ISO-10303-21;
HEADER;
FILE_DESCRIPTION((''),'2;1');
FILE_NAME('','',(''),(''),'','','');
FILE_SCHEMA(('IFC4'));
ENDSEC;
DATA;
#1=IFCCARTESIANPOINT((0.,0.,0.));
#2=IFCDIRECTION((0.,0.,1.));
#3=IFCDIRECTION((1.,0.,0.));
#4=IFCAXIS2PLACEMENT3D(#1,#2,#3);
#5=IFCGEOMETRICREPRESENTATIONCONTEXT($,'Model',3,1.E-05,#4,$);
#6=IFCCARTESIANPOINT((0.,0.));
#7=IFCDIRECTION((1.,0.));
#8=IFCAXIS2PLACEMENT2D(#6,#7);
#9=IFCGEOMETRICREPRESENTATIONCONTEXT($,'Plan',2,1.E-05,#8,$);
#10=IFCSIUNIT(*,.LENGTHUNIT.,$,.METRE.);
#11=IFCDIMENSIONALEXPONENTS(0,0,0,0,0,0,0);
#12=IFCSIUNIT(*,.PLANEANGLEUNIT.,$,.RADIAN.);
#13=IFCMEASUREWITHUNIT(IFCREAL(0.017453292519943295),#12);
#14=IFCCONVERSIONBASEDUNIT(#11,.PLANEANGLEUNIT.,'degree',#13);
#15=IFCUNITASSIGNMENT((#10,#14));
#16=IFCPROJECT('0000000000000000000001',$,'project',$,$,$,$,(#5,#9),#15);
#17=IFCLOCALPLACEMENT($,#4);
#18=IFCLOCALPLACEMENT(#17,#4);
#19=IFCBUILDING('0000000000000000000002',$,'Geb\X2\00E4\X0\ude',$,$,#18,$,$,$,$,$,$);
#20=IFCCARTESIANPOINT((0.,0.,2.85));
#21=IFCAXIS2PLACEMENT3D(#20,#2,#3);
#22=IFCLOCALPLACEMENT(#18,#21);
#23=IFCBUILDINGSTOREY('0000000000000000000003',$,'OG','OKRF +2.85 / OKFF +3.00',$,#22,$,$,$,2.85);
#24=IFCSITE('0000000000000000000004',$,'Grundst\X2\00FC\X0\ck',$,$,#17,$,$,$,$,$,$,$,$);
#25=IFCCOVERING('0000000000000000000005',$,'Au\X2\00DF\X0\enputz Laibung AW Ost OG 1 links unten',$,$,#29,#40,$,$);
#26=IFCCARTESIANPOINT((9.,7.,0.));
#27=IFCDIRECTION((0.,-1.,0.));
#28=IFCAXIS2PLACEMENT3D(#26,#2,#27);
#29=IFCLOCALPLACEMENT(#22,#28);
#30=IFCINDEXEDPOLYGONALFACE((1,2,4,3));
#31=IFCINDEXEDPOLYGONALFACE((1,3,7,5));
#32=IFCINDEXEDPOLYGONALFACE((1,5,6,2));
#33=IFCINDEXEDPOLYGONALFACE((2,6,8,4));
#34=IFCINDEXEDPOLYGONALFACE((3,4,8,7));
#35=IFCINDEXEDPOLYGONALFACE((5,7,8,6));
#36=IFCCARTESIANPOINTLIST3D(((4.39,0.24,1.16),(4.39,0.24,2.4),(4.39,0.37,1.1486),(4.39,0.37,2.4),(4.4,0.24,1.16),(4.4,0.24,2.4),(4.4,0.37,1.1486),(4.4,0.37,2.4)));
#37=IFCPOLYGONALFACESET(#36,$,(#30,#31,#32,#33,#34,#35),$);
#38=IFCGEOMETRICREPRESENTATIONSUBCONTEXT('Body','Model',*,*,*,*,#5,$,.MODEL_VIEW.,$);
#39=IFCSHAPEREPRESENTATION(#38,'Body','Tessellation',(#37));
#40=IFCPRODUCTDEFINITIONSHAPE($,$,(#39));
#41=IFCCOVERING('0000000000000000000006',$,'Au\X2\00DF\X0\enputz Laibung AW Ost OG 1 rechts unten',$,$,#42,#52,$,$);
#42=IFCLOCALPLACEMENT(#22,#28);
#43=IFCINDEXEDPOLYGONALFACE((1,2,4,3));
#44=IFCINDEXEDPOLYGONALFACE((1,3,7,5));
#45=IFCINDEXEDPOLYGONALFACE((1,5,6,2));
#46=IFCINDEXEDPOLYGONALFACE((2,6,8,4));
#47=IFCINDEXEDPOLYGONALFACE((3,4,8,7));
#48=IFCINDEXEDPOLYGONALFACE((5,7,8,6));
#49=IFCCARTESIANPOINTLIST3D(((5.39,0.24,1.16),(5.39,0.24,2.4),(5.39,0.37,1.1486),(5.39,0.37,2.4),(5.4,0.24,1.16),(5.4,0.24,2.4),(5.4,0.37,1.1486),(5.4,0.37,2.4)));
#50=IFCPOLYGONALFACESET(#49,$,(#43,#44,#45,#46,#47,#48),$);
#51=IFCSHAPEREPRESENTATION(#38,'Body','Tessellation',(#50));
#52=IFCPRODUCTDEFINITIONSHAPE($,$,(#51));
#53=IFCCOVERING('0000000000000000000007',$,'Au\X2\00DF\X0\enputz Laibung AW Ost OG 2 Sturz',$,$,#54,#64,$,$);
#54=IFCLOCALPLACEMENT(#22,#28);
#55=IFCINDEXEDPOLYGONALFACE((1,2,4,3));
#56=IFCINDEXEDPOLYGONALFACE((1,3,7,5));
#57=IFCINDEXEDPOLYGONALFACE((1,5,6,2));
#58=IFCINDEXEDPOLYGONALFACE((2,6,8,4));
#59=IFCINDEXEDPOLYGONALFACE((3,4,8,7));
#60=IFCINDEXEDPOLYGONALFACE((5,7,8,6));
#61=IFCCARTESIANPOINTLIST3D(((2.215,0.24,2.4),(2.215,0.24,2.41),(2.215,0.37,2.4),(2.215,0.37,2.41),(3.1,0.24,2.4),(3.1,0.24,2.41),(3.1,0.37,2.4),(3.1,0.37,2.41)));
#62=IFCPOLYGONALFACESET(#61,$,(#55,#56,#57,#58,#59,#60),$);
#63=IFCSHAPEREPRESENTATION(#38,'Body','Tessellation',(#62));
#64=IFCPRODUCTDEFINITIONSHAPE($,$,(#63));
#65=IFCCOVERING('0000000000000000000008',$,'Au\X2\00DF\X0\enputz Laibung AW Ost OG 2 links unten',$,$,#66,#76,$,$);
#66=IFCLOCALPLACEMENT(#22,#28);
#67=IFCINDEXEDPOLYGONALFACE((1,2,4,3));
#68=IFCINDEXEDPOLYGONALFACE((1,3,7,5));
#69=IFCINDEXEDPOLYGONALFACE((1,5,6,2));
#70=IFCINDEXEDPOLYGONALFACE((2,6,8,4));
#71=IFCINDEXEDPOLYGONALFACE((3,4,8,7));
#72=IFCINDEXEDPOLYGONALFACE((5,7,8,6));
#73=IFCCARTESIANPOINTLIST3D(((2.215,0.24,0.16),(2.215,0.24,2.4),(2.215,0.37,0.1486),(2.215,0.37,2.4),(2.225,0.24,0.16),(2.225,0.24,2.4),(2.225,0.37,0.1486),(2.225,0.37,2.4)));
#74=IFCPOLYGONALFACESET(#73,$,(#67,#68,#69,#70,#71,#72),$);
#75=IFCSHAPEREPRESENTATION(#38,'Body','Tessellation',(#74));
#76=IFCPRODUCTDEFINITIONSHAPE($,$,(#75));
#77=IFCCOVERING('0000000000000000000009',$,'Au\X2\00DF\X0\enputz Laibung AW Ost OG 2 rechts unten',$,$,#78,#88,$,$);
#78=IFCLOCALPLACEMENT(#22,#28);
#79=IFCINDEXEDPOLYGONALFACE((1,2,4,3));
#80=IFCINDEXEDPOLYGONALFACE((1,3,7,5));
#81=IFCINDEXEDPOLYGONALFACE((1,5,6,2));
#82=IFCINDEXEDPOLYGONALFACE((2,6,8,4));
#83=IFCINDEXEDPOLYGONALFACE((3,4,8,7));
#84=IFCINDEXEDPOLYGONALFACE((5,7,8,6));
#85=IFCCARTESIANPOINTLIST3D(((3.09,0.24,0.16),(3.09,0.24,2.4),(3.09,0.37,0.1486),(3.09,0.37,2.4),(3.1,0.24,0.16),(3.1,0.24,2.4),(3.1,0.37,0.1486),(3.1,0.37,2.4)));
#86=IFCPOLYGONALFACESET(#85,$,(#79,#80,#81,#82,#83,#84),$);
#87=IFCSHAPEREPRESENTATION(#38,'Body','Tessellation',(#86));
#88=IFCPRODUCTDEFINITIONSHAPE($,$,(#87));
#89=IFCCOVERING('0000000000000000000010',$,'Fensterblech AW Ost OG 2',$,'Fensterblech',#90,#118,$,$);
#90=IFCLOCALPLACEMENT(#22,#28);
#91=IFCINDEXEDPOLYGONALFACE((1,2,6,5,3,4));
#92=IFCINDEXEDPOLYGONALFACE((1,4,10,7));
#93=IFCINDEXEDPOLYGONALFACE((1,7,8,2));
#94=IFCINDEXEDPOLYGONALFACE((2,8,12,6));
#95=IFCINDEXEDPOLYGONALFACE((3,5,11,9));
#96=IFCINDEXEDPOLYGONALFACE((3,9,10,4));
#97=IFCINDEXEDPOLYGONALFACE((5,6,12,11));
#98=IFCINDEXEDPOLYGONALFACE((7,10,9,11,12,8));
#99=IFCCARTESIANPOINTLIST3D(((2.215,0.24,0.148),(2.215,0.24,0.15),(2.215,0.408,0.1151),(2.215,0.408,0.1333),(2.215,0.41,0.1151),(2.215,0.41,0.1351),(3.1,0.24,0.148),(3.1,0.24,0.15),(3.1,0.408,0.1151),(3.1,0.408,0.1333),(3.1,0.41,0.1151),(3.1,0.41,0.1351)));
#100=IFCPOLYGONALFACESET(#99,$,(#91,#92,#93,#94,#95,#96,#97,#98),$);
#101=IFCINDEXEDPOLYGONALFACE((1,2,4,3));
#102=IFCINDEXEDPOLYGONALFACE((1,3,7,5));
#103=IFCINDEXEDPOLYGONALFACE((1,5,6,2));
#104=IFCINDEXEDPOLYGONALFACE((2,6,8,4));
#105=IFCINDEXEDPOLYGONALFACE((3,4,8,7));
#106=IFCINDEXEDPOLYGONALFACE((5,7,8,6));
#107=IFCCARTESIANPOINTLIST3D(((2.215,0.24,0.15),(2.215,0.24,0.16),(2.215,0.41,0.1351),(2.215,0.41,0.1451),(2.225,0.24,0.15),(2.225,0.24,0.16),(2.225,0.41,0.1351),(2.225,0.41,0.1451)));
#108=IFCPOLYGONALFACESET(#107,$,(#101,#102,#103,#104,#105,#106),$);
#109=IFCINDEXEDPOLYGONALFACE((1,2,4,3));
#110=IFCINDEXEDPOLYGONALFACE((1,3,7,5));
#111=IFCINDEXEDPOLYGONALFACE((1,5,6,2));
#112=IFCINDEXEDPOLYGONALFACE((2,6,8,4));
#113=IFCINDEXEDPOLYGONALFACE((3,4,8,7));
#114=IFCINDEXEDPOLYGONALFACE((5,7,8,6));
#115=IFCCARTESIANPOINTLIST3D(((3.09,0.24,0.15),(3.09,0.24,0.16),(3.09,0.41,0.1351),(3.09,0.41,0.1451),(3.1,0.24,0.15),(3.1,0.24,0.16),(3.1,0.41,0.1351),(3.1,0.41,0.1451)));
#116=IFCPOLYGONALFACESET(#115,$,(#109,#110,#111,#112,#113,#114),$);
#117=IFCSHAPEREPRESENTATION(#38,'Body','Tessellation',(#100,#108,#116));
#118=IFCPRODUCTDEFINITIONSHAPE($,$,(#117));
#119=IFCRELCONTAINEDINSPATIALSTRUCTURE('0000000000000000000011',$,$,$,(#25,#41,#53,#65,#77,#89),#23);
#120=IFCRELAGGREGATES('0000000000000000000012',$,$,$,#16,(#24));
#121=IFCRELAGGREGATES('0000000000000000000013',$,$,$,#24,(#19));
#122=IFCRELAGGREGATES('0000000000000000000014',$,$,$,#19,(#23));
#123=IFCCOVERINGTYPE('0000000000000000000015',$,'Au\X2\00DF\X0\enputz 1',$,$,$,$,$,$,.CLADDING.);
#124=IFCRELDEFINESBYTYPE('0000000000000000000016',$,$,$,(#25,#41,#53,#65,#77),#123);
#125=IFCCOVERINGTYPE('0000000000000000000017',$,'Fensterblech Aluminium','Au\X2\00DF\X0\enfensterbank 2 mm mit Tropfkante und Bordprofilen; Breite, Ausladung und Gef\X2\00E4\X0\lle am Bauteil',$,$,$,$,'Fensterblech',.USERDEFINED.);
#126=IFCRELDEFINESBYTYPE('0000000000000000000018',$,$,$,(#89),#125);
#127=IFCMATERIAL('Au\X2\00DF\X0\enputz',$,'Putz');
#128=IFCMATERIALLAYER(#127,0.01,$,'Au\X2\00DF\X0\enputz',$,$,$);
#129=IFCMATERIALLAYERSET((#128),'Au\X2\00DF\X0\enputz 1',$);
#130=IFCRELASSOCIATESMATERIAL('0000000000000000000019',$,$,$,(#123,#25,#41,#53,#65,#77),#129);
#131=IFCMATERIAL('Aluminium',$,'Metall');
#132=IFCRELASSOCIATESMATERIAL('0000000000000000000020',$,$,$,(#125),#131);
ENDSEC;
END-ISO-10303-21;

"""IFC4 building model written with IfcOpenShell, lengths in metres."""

from ifc_helpers import new_model, entity, si_unit, converted_unit, frame, origin_with_axes, origin_2d_with_axis, place, context, subcontext, project, spatial, polyline, outline, extrude, material, layer, layer_set, layer_usage, type_object, element, save


model = new_model("IFC4")

# Units and contexts
model_context = context("Model", 3, precision=1e-05, world=origin_with_axes())
plan_context = context("Plan", 2, precision=1e-05, world=origin_2d_with_axis())
body_context = subcontext(model_context, "Body", "Model", "MODEL_VIEW")
ifc_project = project(units=[si_unit("LENGTHUNIT", "METRE"), converted_unit("PLANEANGLEUNIT", "degree", entity("IfcReal", 0.017453292519943295), si_unit("PLANEANGLEUNIT", "RADIAN"), dimensions=[0, 0, 0, 0, 0, 0, 0])], contexts=[model_context, plan_context])

# Site, building, storey
site_placement = place(None, origin_with_axes())
site = spatial("IfcSite", under=ifc_project, at=site_placement, Name="Grundstück")
building_placement = place(site_placement, origin_with_axes())
building = spatial("IfcBuilding", under=site, at=building_placement, Name="Gebäude")
storey_placement = place(building_placement, frame((0.0, 0.0, 2.85), z_axis=(0.0, 0.0, 1.0), x_axis=(1.0, 0.0, 0.0)))
storey = spatial("IfcBuildingStorey", under=building, at=storey_placement, Name="OG", Description="OKRF +2.85 / OKFF +3.00", Elevation=2.85)

# Coverings
ifc_material_1 = material(Name="Außenputz", Category="Putz")
ifc_layer_1 = layer(ifc_material_1, 0.01, Name="Außenputz")
ifc_layer_set_1 = layer_set([ifc_layer_1], Name="Außenputz 1")
ifc_layer_usage_1 = layer_usage(ifc_layer_set_1, "AXIS1", "POSITIVE", 4.39)
covering_type_1 = type_object("IfcCoveringType", Name="Außenputz 1", PredefinedType="CLADDING", material=ifc_layer_set_1)
covering_1_placement = place(storey_placement, frame((9.0, 7.0, 0.0), z_axis=(0.0, 0.0, 1.0), x_axis=(0.0, -1.0, 0.0)))
element("IfcCovering", 1, at=covering_1_placement, inside=storey, type_object=covering_type_1, material=ifc_layer_usage_1, Name="Außenputz Laibung AW Ost OG 1 links unten", context=body_context, shape_type="SweptSolid", body=[
    extrude(outline(polyline([(0.24, 1.16), (0.37, 1.1486), (0.37, 2.4), (0.24, 2.4), (0.24, 1.16)])), frame((4.39, 0.0, 0.0), z_axis=(1.0, 0.0, 0.0), x_axis=(0.0, 1.0, 0.0)), (0.0, 0.0, 1.0), 0.01),
])
ifc_layer_usage_2 = layer_usage(ifc_layer_set_1, "AXIS1", "POSITIVE", 5.39)
covering_2_placement = place(storey_placement, frame((9.0, 7.0, 0.0), z_axis=(0.0, 0.0, 1.0), x_axis=(0.0, -1.0, 0.0)))
element("IfcCovering", 2, at=covering_2_placement, inside=storey, type_object=covering_type_1, material=ifc_layer_usage_2, Name="Außenputz Laibung AW Ost OG 1 rechts unten", context=body_context, shape_type="SweptSolid", body=[
    extrude(outline(polyline([(0.24, 1.16), (0.37, 1.1486), (0.37, 2.4), (0.24, 2.4), (0.24, 1.16)])), frame((5.39, 0.0, 0.0), z_axis=(1.0, 0.0, 0.0), x_axis=(0.0, 1.0, 0.0)), (0.0, 0.0, 1.0), 0.01),
])
ifc_layer_usage_3 = layer_usage(ifc_layer_set_1, "AXIS3", "POSITIVE", 2.4)
covering_3_placement = place(storey_placement, frame((9.0, 7.0, 0.0), z_axis=(0.0, 0.0, 1.0), x_axis=(0.0, -1.0, 0.0)))
element("IfcCovering", 3, at=covering_3_placement, inside=storey, type_object=covering_type_1, material=ifc_layer_usage_3, Name="Außenputz Laibung AW Ost OG 2 Sturz", context=body_context, shape_type="SweptSolid", body=[
    extrude(outline(polyline([(0.24, 2.4), (0.37, 2.4), (0.37, 2.41), (0.24, 2.41), (0.24, 2.4)])), frame((2.215, 0.0, 0.0), z_axis=(1.0, 0.0, 0.0), x_axis=(0.0, 1.0, 0.0)), (0.0, 0.0, 1.0), 0.885),
])
ifc_layer_usage_4 = layer_usage(ifc_layer_set_1, "AXIS1", "POSITIVE", 2.215)
covering_4_placement = place(storey_placement, frame((9.0, 7.0, 0.0), z_axis=(0.0, 0.0, 1.0), x_axis=(0.0, -1.0, 0.0)))
element("IfcCovering", 4, at=covering_4_placement, inside=storey, type_object=covering_type_1, material=ifc_layer_usage_4, Name="Außenputz Laibung AW Ost OG 2 links unten", context=body_context, shape_type="SweptSolid", body=[
    extrude(outline(polyline([(0.24, 0.16), (0.37, 0.1486), (0.37, 2.4), (0.24, 2.4), (0.24, 0.16)])), frame((2.215, 0.0, 0.0), z_axis=(1.0, 0.0, 0.0), x_axis=(0.0, 1.0, 0.0)), (0.0, 0.0, 1.0), 0.01),
])
ifc_layer_usage_5 = layer_usage(ifc_layer_set_1, "AXIS1", "POSITIVE", 3.09)
covering_5_placement = place(storey_placement, frame((9.0, 7.0, 0.0), z_axis=(0.0, 0.0, 1.0), x_axis=(0.0, -1.0, 0.0)))
element("IfcCovering", 5, at=covering_5_placement, inside=storey, type_object=covering_type_1, material=ifc_layer_usage_5, Name="Außenputz Laibung AW Ost OG 2 rechts unten", context=body_context, shape_type="SweptSolid", body=[
    extrude(outline(polyline([(0.24, 0.16), (0.37, 0.1486), (0.37, 2.4), (0.24, 2.4), (0.24, 0.16)])), frame((3.09, 0.0, 0.0), z_axis=(1.0, 0.0, 0.0), x_axis=(0.0, 1.0, 0.0)), (0.0, 0.0, 1.0), 0.01),
])
ifc_material_2 = material(Name="Aluminium", Category="Metall")
covering_type_2 = type_object("IfcCoveringType", Name="Fensterblech Aluminium", Description="Außenfensterbank 2 mm mit Tropfkante und Bordprofilen; Breite, Ausladung und Gefälle am Bauteil", ElementType="Fensterblech", PredefinedType="USERDEFINED", material=ifc_material_2)
covering_6_placement = place(storey_placement, frame((9.0, 7.0, 0.0), z_axis=(0.0, 0.0, 1.0), x_axis=(0.0, -1.0, 0.0)))
element("IfcCovering", 6, at=covering_6_placement, inside=storey, type_object=covering_type_2, Name="Fensterblech AW Ost OG 2", ObjectType="Fensterblech", context=body_context, shape_type="SweptSolid", body=[
    extrude(outline(polyline([(0.24, 0.148), (0.408, 0.1333), (0.408, 0.1151), (0.41, 0.1151), (0.41, 0.1351), (0.24, 0.15), (0.24, 0.148)])), frame((2.215, 0.0, 0.0), z_axis=(1.0, 0.0, 0.0), x_axis=(0.0, 1.0, 0.0)), (0.0, 0.0, 1.0), 0.885),
    extrude(outline(polyline([(0.24, 0.15), (0.41, 0.1351), (0.41, 0.1451), (0.24, 0.16), (0.24, 0.15)])), frame((2.215, 0.0, 0.0), z_axis=(1.0, 0.0, 0.0), x_axis=(0.0, 1.0, 0.0)), (0.0, 0.0, 1.0), 0.01),
    extrude(outline(polyline([(0.24, 0.15), (0.41, 0.1351), (0.41, 0.1451), (0.24, 0.16), (0.24, 0.15)])), frame((3.09, 0.0, 0.0), z_axis=(1.0, 0.0, 0.0), x_axis=(0.0, 1.0, 0.0)), (0.0, 0.0, 1.0), 0.01),
])

save(model, "model.ifc")
